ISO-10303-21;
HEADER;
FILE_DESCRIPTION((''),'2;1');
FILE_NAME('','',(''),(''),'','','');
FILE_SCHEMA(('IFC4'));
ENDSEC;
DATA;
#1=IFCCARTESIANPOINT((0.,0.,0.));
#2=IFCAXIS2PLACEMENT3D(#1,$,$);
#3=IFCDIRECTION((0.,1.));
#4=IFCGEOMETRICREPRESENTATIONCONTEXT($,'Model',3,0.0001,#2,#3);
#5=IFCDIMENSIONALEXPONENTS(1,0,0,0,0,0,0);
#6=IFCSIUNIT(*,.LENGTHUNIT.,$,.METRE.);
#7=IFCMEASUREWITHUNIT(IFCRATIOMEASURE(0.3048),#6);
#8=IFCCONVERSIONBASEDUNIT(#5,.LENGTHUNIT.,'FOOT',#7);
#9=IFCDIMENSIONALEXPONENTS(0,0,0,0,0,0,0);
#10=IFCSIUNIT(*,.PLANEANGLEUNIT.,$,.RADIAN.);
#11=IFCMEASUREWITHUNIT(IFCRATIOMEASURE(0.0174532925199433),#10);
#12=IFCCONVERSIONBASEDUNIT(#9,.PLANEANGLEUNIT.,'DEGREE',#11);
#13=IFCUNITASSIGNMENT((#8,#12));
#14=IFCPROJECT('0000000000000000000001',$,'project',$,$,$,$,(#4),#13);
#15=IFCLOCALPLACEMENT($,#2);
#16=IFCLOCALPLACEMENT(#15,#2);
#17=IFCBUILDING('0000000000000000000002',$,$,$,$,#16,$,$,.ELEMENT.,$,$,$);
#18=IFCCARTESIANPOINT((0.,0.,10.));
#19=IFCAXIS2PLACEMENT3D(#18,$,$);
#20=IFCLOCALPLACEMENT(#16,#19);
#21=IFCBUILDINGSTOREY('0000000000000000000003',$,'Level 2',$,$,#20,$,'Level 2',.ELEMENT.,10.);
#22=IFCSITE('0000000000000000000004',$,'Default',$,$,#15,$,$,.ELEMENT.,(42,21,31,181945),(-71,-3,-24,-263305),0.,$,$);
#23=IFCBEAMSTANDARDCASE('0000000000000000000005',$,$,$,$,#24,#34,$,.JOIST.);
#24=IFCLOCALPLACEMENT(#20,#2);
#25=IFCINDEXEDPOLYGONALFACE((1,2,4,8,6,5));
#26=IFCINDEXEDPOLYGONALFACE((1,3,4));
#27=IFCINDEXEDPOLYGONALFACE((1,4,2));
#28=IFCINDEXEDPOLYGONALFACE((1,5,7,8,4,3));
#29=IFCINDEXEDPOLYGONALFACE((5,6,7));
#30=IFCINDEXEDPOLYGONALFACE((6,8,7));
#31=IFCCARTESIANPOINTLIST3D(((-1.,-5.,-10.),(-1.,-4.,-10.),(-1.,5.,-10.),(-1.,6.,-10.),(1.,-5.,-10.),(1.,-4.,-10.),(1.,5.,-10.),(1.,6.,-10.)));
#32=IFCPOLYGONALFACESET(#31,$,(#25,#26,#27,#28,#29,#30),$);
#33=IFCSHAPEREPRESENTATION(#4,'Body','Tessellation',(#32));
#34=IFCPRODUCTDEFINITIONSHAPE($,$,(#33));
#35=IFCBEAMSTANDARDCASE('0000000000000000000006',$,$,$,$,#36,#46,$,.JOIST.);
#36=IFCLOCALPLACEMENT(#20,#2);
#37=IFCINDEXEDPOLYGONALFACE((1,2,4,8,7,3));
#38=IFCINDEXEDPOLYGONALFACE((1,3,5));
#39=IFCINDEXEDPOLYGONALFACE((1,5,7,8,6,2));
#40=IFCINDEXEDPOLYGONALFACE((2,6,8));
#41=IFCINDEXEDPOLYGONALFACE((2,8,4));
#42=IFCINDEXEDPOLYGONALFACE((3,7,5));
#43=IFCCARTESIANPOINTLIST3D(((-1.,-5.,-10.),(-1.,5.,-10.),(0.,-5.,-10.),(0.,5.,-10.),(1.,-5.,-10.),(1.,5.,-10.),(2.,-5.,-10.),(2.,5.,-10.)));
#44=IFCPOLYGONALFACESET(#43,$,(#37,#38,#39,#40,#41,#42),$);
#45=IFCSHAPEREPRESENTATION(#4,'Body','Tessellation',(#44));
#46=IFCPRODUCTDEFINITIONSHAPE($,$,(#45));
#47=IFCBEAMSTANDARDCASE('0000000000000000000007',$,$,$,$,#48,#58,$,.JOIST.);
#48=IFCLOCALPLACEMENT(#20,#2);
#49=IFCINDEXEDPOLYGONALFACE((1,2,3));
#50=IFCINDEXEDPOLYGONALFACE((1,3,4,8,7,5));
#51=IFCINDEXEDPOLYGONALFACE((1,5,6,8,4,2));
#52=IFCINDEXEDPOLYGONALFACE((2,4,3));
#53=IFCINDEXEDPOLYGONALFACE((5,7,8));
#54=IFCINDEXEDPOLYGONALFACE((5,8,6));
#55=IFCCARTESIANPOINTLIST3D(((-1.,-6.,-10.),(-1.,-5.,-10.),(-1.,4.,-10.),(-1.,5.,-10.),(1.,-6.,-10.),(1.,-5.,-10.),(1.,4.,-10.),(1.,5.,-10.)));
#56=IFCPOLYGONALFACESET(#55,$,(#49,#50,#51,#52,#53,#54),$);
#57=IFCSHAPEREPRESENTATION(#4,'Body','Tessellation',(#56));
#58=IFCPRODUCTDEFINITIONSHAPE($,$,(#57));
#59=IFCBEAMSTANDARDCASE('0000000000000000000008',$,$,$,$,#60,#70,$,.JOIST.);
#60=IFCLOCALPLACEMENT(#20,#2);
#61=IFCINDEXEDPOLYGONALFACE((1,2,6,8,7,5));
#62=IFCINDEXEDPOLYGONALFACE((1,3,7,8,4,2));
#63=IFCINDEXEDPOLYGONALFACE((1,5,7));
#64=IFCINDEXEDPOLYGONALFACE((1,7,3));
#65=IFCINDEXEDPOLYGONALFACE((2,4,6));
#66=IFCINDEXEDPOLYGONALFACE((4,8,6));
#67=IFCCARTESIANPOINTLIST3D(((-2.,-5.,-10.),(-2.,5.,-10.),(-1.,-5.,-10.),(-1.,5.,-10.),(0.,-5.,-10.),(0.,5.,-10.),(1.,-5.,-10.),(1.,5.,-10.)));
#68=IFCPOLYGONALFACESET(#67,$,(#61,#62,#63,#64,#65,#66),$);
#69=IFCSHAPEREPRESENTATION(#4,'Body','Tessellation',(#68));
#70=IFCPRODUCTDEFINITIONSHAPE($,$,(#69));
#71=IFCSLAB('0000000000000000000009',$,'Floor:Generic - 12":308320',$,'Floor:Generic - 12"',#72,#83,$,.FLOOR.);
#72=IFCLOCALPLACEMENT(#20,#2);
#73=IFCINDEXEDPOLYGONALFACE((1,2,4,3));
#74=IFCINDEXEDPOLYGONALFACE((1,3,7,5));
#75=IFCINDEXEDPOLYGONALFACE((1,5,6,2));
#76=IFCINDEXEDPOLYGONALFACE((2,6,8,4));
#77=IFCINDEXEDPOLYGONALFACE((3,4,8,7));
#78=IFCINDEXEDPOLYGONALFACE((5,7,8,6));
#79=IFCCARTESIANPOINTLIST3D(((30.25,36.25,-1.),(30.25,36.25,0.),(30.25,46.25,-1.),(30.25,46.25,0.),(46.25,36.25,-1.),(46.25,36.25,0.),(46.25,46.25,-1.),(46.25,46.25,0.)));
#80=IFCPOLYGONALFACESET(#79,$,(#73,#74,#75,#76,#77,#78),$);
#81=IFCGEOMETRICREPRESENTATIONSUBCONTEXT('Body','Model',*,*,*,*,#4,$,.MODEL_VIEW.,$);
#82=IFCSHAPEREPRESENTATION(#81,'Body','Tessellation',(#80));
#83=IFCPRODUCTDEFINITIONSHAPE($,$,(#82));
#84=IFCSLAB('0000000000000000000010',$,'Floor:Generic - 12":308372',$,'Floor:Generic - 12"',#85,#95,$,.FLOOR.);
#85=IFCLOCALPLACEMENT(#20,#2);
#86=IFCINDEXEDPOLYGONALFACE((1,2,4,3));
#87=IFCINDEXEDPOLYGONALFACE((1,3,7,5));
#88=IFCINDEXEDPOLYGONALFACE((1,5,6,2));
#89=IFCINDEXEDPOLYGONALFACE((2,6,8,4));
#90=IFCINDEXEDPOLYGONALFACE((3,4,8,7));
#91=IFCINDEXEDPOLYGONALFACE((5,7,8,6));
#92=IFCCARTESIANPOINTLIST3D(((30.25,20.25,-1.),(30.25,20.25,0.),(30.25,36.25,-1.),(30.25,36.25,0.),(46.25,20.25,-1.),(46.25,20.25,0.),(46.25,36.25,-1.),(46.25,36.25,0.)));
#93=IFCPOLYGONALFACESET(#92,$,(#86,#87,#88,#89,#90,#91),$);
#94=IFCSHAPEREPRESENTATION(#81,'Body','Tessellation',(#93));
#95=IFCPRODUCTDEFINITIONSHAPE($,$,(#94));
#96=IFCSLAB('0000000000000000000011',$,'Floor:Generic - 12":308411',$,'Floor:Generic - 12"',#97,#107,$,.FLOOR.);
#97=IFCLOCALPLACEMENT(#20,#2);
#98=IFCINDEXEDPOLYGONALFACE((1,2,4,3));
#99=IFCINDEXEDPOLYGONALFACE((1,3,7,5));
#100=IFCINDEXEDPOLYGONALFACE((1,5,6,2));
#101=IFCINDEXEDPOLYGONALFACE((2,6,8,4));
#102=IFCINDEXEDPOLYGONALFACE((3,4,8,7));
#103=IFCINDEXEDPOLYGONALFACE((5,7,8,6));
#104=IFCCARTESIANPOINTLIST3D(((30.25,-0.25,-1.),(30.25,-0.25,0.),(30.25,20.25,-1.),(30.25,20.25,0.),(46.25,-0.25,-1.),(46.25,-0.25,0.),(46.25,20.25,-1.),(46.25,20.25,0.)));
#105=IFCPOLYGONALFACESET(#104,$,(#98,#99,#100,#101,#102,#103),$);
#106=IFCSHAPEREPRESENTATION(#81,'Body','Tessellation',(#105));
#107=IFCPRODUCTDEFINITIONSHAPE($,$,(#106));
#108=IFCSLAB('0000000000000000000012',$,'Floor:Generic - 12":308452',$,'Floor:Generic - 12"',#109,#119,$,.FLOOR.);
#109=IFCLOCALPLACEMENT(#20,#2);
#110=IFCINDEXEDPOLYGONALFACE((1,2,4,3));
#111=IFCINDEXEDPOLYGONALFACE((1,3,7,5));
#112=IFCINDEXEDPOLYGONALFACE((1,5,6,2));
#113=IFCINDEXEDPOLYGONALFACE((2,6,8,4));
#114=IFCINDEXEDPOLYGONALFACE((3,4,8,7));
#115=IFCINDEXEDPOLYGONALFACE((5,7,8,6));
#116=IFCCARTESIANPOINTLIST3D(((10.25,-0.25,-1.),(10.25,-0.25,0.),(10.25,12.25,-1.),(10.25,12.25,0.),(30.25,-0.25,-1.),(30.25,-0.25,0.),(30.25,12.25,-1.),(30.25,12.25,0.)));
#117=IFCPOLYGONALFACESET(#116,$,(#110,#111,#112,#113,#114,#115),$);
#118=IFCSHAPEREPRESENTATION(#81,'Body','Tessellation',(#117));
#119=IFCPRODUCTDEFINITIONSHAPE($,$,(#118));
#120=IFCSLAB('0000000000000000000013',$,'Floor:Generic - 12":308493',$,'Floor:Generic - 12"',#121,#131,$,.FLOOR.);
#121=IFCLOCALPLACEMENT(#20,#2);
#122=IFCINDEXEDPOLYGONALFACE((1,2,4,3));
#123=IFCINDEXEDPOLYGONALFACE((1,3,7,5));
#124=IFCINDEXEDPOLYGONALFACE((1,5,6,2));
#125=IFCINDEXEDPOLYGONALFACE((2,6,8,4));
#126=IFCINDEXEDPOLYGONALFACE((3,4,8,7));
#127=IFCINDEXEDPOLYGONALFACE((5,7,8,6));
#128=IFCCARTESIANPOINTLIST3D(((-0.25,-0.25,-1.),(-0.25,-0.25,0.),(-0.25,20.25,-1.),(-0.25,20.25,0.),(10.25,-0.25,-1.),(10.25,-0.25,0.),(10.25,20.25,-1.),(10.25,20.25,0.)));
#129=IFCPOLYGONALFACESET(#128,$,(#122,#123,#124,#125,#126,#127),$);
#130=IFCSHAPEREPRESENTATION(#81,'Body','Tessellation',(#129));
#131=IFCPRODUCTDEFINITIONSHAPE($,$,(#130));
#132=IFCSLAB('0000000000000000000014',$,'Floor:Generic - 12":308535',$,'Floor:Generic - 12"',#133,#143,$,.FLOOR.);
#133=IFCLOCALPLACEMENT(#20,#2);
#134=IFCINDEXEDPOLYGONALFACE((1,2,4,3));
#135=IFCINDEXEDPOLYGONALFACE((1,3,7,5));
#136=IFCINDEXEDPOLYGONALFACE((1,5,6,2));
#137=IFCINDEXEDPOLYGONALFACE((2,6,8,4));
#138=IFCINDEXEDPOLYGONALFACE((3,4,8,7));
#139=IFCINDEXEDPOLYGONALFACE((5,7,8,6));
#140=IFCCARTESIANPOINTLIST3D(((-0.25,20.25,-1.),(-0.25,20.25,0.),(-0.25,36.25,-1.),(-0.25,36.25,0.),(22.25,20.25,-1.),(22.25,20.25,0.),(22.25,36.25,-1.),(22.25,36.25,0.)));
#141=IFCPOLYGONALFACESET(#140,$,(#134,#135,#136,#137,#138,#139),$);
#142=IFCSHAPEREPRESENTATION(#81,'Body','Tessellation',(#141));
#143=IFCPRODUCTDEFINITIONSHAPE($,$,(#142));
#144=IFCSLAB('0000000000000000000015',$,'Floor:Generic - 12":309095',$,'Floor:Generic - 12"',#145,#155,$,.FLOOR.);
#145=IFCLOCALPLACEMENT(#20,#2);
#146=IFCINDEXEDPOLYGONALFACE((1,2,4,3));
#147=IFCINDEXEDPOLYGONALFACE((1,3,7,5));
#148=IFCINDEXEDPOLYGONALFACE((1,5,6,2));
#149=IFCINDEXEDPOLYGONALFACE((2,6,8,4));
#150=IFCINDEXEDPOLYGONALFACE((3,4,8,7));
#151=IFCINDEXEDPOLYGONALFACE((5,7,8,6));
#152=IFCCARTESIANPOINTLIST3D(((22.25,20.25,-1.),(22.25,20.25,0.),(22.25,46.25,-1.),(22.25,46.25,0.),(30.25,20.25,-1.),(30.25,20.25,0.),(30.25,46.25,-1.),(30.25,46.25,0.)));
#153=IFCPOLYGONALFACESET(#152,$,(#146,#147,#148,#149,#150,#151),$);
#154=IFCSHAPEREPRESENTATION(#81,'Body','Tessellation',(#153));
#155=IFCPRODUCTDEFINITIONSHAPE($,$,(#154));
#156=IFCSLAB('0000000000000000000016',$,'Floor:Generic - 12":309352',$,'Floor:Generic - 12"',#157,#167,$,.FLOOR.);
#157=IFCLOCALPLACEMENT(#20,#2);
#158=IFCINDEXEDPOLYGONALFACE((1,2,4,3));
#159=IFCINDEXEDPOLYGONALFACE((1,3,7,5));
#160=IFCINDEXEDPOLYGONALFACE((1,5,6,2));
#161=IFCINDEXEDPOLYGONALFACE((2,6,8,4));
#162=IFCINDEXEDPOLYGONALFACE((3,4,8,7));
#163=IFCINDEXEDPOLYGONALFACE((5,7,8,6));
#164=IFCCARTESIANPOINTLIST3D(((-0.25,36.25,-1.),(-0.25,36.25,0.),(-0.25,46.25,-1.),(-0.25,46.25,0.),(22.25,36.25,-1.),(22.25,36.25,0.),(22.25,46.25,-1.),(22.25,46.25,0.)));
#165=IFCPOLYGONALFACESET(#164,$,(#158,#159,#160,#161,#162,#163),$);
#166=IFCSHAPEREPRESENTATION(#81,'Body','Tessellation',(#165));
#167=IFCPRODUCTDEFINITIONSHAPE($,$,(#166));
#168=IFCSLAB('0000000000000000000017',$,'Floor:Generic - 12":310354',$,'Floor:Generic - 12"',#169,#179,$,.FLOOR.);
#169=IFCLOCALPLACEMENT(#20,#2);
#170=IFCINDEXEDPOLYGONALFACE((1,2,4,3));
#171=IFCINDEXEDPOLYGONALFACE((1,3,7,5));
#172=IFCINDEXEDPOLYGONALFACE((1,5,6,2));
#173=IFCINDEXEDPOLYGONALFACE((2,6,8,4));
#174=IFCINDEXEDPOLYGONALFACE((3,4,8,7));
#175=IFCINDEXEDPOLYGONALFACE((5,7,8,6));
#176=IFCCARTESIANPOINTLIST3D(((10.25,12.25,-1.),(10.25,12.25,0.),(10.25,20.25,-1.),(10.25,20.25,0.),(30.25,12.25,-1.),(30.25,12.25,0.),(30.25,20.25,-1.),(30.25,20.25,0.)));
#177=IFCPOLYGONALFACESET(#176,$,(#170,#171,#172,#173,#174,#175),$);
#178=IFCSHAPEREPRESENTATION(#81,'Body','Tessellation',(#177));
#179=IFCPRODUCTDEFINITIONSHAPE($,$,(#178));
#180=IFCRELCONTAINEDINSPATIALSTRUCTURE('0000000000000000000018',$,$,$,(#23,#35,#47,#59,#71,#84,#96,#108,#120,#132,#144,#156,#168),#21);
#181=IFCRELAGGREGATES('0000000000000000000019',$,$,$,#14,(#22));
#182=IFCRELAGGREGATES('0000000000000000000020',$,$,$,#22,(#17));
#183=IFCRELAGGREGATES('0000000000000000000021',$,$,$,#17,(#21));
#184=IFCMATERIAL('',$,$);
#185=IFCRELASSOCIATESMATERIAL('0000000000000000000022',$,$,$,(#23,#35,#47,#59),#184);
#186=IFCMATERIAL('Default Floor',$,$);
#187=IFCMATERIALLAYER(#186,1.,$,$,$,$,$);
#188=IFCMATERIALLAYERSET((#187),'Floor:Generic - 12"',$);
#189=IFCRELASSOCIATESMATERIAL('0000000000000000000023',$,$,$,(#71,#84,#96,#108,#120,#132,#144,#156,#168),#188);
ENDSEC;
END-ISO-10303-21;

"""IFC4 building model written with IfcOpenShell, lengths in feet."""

from ifc_helpers import new_model, entity, si_unit, converted_unit, direction, frame, frame_2d, origin, place, context, subcontext, project, spatial, rectangle, extrude, material, layer, layer_set, layer_usage, element, save


model = new_model("IFC4")

# Units and contexts
model_context = context("Model", 3, precision=0.0001, world=origin(), true_north=direction((0.0, 1.0)))
body_context = subcontext(model_context, "Body", "Model", "MODEL_VIEW")
ifc_project = project(units=[converted_unit("LENGTHUNIT", "FOOT", entity("IfcRatioMeasure", 0.3048), si_unit("LENGTHUNIT", "METRE"), dimensions=[1, 0, 0, 0, 0, 0, 0]), converted_unit("PLANEANGLEUNIT", "DEGREE", entity("IfcRatioMeasure", 0.0174532925199433), si_unit("PLANEANGLEUNIT", "RADIAN"), dimensions=[0, 0, 0, 0, 0, 0, 0])], contexts=[model_context])

# Site, building, storey
site_placement = place(None, origin())
site = spatial("IfcSite", under=ifc_project, at=site_placement, Name="Default", CompositionType="ELEMENT", RefLatitude=(42, 21, 31, 181945), RefLongitude=(-71, -3, -24, -263305), RefElevation=0.0)
building_placement = place(site_placement, origin())
building = spatial("IfcBuilding", under=site, at=building_placement, CompositionType="ELEMENT")
storey_placement = place(building_placement, frame((0.0, 0.0, 10.0)))
storey = spatial("IfcBuildingStorey", under=building, at=storey_placement, Name="Level 2", LongName="Level 2", CompositionType="ELEMENT", Elevation=10.0)

# Beams
ifc_material_1 = material(Name="")
element("IfcBeamStandardCase", 1, inside=storey, material=ifc_material_1, PredefinedType="JOIST", context=model_context, shape_type="SweptSolid", body=[
    extrude(rectangle(XDim=2.0, YDim=10.0), origin(), (0.0, 1.0, 0.0), 1.0),
])
element("IfcBeamStandardCase", 2, inside=storey, material=ifc_material_1, PredefinedType="JOIST", context=model_context, shape_type="SweptSolid", body=[
    extrude(rectangle(XDim=2.0, YDim=10.0), origin(), (1.0, 0.0, 0.0), 1.0),
])
element("IfcBeamStandardCase", 3, inside=storey, material=ifc_material_1, PredefinedType="JOIST", context=model_context, shape_type="SweptSolid", body=[
    extrude(rectangle(XDim=2.0, YDim=10.0), origin(), (0.0, -1.0, 0.0), 1.0),
])
element("IfcBeamStandardCase", 4, inside=storey, material=ifc_material_1, PredefinedType="JOIST", context=model_context, shape_type="SweptSolid", body=[
    extrude(rectangle(XDim=2.0, YDim=10.0), origin(), (-1.0, 0.0, 0.0), 1.0),
])

# Slabs
ifc_material_2 = material(Name="Default Floor")
ifc_layer = layer(ifc_material_2, 1.0)
ifc_layer_set = layer_set([ifc_layer], Name="Floor:Generic - 12\"")
ifc_layer_usage_1 = layer_usage(ifc_layer_set, "AXIS3", "POSITIVE", 0.0)
slab_1_placement = place(storey_placement, origin())
element("IfcSlab", 5, at=slab_1_placement, inside=storey, material=ifc_layer_usage_1, Name="Floor:Generic - 12\":308320", ObjectType="Floor:Generic - 12\"", PredefinedType="FLOOR", context=body_context, shape_type="SweptSolid", body=[
    extrude(rectangle(XDim=10.0, YDim=16.0, at=frame_2d((0.0, 0.0), x_axis=(1.0, 0.0))), frame((38.25, 41.25, 0.0), z_axis=(0.0, 0.0, -1.0), x_axis=(0.0, 1.0, 0.0)), (0.0, 0.0, 1.0), 1.0),
])
ifc_layer_usage_2 = layer_usage(ifc_layer_set, "AXIS3", "POSITIVE", 0.0)
slab_2_placement = place(storey_placement, origin())
element("IfcSlab", 6, at=slab_2_placement, inside=storey, material=ifc_layer_usage_2, Name="Floor:Generic - 12\":308372", ObjectType="Floor:Generic - 12\"", PredefinedType="FLOOR", context=body_context, shape_type="SweptSolid", body=[
    extrude(rectangle(XDim=16.0, YDim=16.0, at=frame_2d((0.0, 0.0), x_axis=(1.0, 0.0))), frame((38.25, 28.25, 0.0), z_axis=(0.0, 0.0, -1.0), x_axis=(0.0, 1.0, 0.0)), (0.0, 0.0, 1.0), 1.0),
])
ifc_layer_usage_3 = layer_usage(ifc_layer_set, "AXIS3", "POSITIVE", 0.0)
slab_3_placement = place(storey_placement, origin())
element("IfcSlab", 7, at=slab_3_placement, inside=storey, material=ifc_layer_usage_3, Name="Floor:Generic - 12\":308411", ObjectType="Floor:Generic - 12\"", PredefinedType="FLOOR", context=body_context, shape_type="SweptSolid", body=[
    extrude(rectangle(XDim=20.5, YDim=16.0, at=frame_2d((0.0, 0.0), x_axis=(1.0, 0.0))), frame((38.25, 10.0, 0.0), z_axis=(0.0, 0.0, -1.0), x_axis=(0.0, 1.0, 0.0)), (0.0, 0.0, 1.0), 1.0),
])
ifc_layer_usage_4 = layer_usage(ifc_layer_set, "AXIS3", "POSITIVE", 0.0)
slab_4_placement = place(storey_placement, origin())
element("IfcSlab", 8, at=slab_4_placement, inside=storey, material=ifc_layer_usage_4, Name="Floor:Generic - 12\":308452", ObjectType="Floor:Generic - 12\"", PredefinedType="FLOOR", context=body_context, shape_type="SweptSolid", body=[
    extrude(rectangle(XDim=12.5, YDim=20.0, at=frame_2d((0.0, 0.0), x_axis=(1.0, 0.0))), frame((20.25, 6.0, 0.0), z_axis=(0.0, 0.0, -1.0), x_axis=(0.0, 1.0, 0.0)), (0.0, 0.0, 1.0), 1.0),
])
ifc_layer_usage_5 = layer_usage(ifc_layer_set, "AXIS3", "POSITIVE", 0.0)
slab_5_placement = place(storey_placement, origin())
element("IfcSlab", 9, at=slab_5_placement, inside=storey, material=ifc_layer_usage_5, Name="Floor:Generic - 12\":308493", ObjectType="Floor:Generic - 12\"", PredefinedType="FLOOR", context=body_context, shape_type="SweptSolid", body=[
    extrude(rectangle(XDim=20.5, YDim=10.5, at=frame_2d((0.0, 0.0), x_axis=(1.0, 0.0))), frame((5.0, 10.0, 0.0), z_axis=(0.0, 0.0, -1.0), x_axis=(0.0, 1.0, 0.0)), (0.0, 0.0, 1.0), 1.0),
])
ifc_layer_usage_6 = layer_usage(ifc_layer_set, "AXIS3", "POSITIVE", 0.0)
slab_6_placement = place(storey_placement, origin())
element("IfcSlab", 10, at=slab_6_placement, inside=storey, material=ifc_layer_usage_6, Name="Floor:Generic - 12\":308535", ObjectType="Floor:Generic - 12\"", PredefinedType="FLOOR", context=body_context, shape_type="SweptSolid", body=[
    extrude(rectangle(XDim=16.0, YDim=22.5, at=frame_2d((0.0, 0.0), x_axis=(1.0, 0.0))), frame((11.0, 28.25, 0.0), z_axis=(0.0, 0.0, -1.0), x_axis=(0.0, 1.0, 0.0)), (0.0, 0.0, 1.0), 1.0),
])
ifc_layer_usage_7 = layer_usage(ifc_layer_set, "AXIS3", "POSITIVE", 0.0)
slab_7_placement = place(storey_placement, origin())
element("IfcSlab", 11, at=slab_7_placement, inside=storey, material=ifc_layer_usage_7, Name="Floor:Generic - 12\":309095", ObjectType="Floor:Generic - 12\"", PredefinedType="FLOOR", context=body_context, shape_type="SweptSolid", body=[
    extrude(rectangle(XDim=26.0, YDim=8.0, at=frame_2d((0.0, 0.0), x_axis=(1.0, 0.0))), frame((26.25, 33.25, 0.0), z_axis=(0.0, 0.0, -1.0), x_axis=(0.0, 1.0, 0.0)), (0.0, 0.0, 1.0), 1.0),
])
ifc_layer_usage_8 = layer_usage(ifc_layer_set, "AXIS3", "POSITIVE", 0.0)
slab_8_placement = place(storey_placement, origin())
element("IfcSlab", 12, at=slab_8_placement, inside=storey, material=ifc_layer_usage_8, Name="Floor:Generic - 12\":309352", ObjectType="Floor:Generic - 12\"", PredefinedType="FLOOR", context=body_context, shape_type="SweptSolid", body=[
    extrude(rectangle(XDim=10.0, YDim=22.5, at=frame_2d((0.0, 0.0), x_axis=(1.0, 0.0))), frame((11.0, 41.25, 0.0), z_axis=(0.0, 0.0, -1.0), x_axis=(0.0, 1.0, 0.0)), (0.0, 0.0, 1.0), 1.0),
])
ifc_layer_usage_9 = layer_usage(ifc_layer_set, "AXIS3", "POSITIVE", 0.0)
slab_9_placement = place(storey_placement, origin())
element("IfcSlab", 13, at=slab_9_placement, inside=storey, material=ifc_layer_usage_9, Name="Floor:Generic - 12\":310354", ObjectType="Floor:Generic - 12\"", PredefinedType="FLOOR", context=body_context, shape_type="SweptSolid", body=[
    extrude(rectangle(XDim=8.0, YDim=20.0, at=frame_2d((0.0, 0.0), x_axis=(1.0, 0.0))), frame((20.25, 16.25, 0.0), z_axis=(0.0, 0.0, -1.0), x_axis=(0.0, 1.0, 0.0)), (0.0, 0.0, 1.0), 1.0),
])

save(model, "model.ifc")
